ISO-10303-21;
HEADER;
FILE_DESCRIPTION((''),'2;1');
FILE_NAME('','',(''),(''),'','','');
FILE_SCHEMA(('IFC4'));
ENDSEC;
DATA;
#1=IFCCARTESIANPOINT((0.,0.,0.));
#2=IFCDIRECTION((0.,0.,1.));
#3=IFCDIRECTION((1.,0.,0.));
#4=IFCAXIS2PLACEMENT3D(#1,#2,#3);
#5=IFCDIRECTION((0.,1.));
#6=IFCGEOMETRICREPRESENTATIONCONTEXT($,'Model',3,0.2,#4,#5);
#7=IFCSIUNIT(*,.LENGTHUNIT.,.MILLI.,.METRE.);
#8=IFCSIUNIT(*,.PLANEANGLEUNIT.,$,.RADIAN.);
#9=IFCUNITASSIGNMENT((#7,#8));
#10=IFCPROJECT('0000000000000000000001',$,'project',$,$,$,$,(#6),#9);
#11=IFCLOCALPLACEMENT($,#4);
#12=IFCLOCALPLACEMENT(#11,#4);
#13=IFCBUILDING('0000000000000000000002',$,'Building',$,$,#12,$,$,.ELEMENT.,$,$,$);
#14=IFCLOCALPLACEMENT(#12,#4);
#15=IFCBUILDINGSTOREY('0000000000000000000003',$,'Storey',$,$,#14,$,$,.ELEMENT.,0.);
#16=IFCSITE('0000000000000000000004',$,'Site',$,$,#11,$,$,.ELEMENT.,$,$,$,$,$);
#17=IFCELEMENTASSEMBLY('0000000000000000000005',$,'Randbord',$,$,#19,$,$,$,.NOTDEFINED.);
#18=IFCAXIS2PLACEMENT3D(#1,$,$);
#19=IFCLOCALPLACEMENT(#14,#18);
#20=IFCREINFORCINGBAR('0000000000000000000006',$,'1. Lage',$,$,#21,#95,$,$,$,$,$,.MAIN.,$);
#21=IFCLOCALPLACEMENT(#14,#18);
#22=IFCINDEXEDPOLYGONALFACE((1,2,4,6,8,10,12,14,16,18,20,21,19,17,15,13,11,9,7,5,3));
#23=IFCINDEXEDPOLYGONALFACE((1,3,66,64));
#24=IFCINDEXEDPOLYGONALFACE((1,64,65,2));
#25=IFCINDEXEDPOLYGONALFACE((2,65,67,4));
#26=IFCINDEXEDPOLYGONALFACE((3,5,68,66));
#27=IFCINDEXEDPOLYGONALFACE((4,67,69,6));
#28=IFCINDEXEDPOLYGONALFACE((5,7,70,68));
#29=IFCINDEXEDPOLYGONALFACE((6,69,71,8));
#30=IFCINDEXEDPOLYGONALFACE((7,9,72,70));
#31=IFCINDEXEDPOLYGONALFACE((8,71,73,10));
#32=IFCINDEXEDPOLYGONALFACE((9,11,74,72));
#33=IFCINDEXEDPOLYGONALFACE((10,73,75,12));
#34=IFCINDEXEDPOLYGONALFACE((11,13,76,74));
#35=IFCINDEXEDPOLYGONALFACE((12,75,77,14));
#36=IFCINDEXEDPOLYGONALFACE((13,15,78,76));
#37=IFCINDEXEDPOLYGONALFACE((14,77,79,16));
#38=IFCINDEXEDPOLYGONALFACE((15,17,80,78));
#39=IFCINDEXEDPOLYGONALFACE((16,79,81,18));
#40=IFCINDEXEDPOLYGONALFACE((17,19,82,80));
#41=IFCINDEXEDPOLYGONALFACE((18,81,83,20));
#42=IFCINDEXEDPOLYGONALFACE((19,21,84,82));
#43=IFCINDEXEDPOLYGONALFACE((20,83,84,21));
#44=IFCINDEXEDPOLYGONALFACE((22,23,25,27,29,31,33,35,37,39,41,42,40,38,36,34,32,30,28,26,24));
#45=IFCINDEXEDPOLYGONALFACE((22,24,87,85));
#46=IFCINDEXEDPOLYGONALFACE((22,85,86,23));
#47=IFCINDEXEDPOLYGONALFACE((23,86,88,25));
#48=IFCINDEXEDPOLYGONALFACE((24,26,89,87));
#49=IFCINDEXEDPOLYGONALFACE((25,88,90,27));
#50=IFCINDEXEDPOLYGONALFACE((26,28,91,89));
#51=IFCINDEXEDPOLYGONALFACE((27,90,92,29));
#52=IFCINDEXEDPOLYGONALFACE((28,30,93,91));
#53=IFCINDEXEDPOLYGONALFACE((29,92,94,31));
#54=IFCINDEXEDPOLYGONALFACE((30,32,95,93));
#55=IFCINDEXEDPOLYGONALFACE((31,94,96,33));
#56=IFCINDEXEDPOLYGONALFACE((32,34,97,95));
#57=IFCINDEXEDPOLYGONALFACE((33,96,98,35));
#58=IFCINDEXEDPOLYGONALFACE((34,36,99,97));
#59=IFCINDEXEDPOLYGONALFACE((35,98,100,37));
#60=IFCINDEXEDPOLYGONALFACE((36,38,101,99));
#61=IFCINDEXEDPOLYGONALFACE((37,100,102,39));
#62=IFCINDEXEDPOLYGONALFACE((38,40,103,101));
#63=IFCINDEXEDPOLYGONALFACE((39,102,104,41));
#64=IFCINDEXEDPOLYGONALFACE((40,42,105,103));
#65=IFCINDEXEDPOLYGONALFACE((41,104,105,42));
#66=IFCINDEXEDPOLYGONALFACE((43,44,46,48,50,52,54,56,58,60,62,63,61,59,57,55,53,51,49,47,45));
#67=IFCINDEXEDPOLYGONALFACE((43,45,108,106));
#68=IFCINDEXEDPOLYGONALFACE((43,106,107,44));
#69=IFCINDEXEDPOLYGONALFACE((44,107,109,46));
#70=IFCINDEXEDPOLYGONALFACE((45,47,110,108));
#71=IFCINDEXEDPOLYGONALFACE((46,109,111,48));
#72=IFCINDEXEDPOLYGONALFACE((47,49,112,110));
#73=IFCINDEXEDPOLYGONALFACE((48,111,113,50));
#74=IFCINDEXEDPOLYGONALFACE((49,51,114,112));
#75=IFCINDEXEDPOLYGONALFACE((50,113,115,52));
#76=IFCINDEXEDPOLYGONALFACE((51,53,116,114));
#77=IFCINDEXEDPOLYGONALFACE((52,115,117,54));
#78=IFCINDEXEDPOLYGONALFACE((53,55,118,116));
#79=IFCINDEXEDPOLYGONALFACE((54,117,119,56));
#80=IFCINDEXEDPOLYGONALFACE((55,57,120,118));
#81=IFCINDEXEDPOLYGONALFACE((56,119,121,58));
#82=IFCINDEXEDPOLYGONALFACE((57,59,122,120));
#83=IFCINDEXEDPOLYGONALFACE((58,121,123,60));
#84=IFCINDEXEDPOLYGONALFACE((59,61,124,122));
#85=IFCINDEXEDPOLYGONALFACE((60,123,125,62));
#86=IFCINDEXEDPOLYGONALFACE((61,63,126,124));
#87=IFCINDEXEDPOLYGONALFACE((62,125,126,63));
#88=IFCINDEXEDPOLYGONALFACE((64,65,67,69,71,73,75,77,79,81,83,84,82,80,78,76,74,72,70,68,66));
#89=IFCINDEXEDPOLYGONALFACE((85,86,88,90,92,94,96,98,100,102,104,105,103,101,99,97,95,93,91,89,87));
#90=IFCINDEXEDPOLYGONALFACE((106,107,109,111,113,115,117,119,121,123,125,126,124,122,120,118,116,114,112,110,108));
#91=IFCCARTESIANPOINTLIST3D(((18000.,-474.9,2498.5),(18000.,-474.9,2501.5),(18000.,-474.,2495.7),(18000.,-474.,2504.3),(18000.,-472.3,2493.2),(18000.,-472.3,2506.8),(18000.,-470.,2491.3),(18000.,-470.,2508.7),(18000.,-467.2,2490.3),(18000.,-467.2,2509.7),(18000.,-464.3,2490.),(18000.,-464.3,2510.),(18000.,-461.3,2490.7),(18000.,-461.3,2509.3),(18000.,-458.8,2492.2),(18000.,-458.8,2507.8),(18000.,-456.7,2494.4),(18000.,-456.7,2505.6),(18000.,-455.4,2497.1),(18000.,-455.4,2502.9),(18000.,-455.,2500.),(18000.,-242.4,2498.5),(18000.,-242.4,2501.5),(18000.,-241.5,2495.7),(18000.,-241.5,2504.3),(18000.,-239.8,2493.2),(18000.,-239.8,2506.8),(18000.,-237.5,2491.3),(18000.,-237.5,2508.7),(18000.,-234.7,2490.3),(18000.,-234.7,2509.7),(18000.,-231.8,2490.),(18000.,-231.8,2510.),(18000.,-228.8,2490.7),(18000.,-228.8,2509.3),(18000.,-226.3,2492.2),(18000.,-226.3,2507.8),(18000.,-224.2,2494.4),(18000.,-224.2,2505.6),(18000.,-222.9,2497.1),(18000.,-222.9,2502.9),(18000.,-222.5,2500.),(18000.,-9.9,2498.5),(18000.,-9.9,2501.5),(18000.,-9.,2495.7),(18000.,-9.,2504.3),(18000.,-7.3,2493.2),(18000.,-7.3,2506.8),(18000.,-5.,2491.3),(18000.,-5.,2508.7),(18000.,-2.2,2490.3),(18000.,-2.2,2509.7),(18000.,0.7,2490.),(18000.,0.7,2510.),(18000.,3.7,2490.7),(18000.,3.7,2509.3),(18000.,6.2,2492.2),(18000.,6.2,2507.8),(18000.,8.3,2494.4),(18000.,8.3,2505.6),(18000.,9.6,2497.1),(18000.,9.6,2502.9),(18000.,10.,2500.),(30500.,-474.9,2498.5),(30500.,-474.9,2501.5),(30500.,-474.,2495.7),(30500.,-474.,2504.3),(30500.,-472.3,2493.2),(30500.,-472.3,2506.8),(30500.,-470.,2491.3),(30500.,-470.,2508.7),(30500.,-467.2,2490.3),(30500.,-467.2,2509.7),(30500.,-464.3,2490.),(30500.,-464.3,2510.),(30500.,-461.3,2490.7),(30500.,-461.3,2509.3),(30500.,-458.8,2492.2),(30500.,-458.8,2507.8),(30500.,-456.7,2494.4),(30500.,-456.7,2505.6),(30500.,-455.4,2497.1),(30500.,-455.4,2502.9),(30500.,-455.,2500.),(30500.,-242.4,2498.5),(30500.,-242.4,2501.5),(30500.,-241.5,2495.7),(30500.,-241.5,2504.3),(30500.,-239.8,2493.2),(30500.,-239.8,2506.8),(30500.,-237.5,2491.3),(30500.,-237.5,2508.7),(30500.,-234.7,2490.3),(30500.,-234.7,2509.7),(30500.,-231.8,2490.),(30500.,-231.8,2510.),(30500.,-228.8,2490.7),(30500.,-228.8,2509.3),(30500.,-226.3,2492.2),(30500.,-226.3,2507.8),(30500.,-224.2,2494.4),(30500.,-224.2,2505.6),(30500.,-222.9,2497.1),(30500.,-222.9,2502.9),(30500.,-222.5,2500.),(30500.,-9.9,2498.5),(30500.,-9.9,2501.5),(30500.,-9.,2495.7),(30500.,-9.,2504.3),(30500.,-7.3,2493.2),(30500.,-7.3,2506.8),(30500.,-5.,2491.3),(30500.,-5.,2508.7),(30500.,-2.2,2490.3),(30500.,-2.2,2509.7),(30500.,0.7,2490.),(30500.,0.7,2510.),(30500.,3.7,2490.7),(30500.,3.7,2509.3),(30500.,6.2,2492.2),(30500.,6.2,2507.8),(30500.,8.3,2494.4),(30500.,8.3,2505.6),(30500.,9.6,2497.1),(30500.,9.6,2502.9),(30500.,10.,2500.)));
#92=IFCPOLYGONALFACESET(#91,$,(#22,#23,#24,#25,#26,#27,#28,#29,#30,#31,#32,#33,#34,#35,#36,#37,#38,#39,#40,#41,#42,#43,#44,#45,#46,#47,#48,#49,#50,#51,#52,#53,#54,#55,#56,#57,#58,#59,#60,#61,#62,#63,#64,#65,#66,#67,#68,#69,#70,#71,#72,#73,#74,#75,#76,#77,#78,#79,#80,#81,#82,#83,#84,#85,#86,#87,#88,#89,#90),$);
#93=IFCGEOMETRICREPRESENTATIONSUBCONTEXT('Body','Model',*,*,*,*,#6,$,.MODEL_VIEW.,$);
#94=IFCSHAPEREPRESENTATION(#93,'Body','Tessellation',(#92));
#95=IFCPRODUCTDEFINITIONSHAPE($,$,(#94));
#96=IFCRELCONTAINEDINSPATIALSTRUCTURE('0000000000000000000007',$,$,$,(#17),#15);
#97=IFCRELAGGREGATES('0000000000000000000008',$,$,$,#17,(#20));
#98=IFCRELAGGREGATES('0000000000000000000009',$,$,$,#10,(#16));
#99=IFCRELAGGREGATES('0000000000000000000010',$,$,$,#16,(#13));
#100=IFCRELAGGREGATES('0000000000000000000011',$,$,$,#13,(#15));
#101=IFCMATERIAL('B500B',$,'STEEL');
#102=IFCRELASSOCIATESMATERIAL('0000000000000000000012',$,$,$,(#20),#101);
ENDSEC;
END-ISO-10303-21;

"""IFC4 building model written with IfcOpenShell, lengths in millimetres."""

from ifc_helpers import new_model, entity, si_unit, direction, frame, origin_with_axes, place, context, subcontext, project, spatial, source, transform, mapped, material, element, aggregate, save


model = new_model("IFC4")

# Units and contexts
model_context = context("Model", 3, precision=0.2, world=origin_with_axes(), true_north=direction((0.0, 1.0)))
body_context = subcontext(model_context, "Body", "Model", "MODEL_VIEW")
ifc_project = project(units=[si_unit("LENGTHUNIT", "METRE", prefix="MILLI"), si_unit("PLANEANGLEUNIT", "RADIAN")], contexts=[model_context])

# Site, building, storey
site_placement = place(None, origin_with_axes())
site = spatial("IfcSite", under=ifc_project, at=site_placement, Name="Site", CompositionType="ELEMENT")
building_placement = place(site_placement, origin_with_axes())
building = spatial("IfcBuilding", under=site, at=building_placement, Name="Building", CompositionType="ELEMENT")
storey_placement = place(building_placement, origin_with_axes())
storey = spatial("IfcBuildingStorey", under=building, at=storey_placement, Name="Storey", CompositionType="ELEMENT", Elevation=0.0)

# Shared definitions
ifc_material_1 = material(Name="B500B", Category="STEEL")

# Element assembly, reinforcing bar
assembly_placement = place(storey_placement, frame((30500.0, -250.0, 2950.0), z_axis=(0.0, 1.0, 0.0), x_axis=(-1.0, 0.0, 0.0)))
assembly = element("IfcElementAssembly", 1, at=assembly_placement, inside=storey, Name="Randbord", PredefinedType="NOTDEFINED")
shared_shape_1 = source(origin_with_axes(), body_context, "Body", "AdvancedSweptSolid", [
    entity("IfcSweptDiskSolid", entity("IfcIndexedPolyCurve", entity("IfcCartesianPointList3D", [[0.0, 0.0, 0.0], [12500.0, 0.0, 0.0]]), [entity("IfcLineIndex", [1, 2])]), 10.0),
])
reinforcing_bar_1_placement = place(assembly_placement, frame((0.0, -450.0, -215.0), z_axis=(0.0, 0.0, 1.0), x_axis=(1.0, 0.0, 0.0)))
reinforcing_bar_1 = element("IfcReinforcingBar", 2, at=reinforcing_bar_1_placement, material=ifc_material_1, Name="1. Lage", PredefinedType="MAIN", context=body_context, shape_type="MappedRepresentation", body=[
    mapped(shared_shape_1, transform((0.0, 0.0, 0.0))),
    mapped(shared_shape_1, transform((0.0, 0.0, 232.5))),
    mapped(shared_shape_1, transform((0.0, 0.0, 465.0))),
])
aggregate(assembly, [reinforcing_bar_1])

save(model, "model.ifc")
